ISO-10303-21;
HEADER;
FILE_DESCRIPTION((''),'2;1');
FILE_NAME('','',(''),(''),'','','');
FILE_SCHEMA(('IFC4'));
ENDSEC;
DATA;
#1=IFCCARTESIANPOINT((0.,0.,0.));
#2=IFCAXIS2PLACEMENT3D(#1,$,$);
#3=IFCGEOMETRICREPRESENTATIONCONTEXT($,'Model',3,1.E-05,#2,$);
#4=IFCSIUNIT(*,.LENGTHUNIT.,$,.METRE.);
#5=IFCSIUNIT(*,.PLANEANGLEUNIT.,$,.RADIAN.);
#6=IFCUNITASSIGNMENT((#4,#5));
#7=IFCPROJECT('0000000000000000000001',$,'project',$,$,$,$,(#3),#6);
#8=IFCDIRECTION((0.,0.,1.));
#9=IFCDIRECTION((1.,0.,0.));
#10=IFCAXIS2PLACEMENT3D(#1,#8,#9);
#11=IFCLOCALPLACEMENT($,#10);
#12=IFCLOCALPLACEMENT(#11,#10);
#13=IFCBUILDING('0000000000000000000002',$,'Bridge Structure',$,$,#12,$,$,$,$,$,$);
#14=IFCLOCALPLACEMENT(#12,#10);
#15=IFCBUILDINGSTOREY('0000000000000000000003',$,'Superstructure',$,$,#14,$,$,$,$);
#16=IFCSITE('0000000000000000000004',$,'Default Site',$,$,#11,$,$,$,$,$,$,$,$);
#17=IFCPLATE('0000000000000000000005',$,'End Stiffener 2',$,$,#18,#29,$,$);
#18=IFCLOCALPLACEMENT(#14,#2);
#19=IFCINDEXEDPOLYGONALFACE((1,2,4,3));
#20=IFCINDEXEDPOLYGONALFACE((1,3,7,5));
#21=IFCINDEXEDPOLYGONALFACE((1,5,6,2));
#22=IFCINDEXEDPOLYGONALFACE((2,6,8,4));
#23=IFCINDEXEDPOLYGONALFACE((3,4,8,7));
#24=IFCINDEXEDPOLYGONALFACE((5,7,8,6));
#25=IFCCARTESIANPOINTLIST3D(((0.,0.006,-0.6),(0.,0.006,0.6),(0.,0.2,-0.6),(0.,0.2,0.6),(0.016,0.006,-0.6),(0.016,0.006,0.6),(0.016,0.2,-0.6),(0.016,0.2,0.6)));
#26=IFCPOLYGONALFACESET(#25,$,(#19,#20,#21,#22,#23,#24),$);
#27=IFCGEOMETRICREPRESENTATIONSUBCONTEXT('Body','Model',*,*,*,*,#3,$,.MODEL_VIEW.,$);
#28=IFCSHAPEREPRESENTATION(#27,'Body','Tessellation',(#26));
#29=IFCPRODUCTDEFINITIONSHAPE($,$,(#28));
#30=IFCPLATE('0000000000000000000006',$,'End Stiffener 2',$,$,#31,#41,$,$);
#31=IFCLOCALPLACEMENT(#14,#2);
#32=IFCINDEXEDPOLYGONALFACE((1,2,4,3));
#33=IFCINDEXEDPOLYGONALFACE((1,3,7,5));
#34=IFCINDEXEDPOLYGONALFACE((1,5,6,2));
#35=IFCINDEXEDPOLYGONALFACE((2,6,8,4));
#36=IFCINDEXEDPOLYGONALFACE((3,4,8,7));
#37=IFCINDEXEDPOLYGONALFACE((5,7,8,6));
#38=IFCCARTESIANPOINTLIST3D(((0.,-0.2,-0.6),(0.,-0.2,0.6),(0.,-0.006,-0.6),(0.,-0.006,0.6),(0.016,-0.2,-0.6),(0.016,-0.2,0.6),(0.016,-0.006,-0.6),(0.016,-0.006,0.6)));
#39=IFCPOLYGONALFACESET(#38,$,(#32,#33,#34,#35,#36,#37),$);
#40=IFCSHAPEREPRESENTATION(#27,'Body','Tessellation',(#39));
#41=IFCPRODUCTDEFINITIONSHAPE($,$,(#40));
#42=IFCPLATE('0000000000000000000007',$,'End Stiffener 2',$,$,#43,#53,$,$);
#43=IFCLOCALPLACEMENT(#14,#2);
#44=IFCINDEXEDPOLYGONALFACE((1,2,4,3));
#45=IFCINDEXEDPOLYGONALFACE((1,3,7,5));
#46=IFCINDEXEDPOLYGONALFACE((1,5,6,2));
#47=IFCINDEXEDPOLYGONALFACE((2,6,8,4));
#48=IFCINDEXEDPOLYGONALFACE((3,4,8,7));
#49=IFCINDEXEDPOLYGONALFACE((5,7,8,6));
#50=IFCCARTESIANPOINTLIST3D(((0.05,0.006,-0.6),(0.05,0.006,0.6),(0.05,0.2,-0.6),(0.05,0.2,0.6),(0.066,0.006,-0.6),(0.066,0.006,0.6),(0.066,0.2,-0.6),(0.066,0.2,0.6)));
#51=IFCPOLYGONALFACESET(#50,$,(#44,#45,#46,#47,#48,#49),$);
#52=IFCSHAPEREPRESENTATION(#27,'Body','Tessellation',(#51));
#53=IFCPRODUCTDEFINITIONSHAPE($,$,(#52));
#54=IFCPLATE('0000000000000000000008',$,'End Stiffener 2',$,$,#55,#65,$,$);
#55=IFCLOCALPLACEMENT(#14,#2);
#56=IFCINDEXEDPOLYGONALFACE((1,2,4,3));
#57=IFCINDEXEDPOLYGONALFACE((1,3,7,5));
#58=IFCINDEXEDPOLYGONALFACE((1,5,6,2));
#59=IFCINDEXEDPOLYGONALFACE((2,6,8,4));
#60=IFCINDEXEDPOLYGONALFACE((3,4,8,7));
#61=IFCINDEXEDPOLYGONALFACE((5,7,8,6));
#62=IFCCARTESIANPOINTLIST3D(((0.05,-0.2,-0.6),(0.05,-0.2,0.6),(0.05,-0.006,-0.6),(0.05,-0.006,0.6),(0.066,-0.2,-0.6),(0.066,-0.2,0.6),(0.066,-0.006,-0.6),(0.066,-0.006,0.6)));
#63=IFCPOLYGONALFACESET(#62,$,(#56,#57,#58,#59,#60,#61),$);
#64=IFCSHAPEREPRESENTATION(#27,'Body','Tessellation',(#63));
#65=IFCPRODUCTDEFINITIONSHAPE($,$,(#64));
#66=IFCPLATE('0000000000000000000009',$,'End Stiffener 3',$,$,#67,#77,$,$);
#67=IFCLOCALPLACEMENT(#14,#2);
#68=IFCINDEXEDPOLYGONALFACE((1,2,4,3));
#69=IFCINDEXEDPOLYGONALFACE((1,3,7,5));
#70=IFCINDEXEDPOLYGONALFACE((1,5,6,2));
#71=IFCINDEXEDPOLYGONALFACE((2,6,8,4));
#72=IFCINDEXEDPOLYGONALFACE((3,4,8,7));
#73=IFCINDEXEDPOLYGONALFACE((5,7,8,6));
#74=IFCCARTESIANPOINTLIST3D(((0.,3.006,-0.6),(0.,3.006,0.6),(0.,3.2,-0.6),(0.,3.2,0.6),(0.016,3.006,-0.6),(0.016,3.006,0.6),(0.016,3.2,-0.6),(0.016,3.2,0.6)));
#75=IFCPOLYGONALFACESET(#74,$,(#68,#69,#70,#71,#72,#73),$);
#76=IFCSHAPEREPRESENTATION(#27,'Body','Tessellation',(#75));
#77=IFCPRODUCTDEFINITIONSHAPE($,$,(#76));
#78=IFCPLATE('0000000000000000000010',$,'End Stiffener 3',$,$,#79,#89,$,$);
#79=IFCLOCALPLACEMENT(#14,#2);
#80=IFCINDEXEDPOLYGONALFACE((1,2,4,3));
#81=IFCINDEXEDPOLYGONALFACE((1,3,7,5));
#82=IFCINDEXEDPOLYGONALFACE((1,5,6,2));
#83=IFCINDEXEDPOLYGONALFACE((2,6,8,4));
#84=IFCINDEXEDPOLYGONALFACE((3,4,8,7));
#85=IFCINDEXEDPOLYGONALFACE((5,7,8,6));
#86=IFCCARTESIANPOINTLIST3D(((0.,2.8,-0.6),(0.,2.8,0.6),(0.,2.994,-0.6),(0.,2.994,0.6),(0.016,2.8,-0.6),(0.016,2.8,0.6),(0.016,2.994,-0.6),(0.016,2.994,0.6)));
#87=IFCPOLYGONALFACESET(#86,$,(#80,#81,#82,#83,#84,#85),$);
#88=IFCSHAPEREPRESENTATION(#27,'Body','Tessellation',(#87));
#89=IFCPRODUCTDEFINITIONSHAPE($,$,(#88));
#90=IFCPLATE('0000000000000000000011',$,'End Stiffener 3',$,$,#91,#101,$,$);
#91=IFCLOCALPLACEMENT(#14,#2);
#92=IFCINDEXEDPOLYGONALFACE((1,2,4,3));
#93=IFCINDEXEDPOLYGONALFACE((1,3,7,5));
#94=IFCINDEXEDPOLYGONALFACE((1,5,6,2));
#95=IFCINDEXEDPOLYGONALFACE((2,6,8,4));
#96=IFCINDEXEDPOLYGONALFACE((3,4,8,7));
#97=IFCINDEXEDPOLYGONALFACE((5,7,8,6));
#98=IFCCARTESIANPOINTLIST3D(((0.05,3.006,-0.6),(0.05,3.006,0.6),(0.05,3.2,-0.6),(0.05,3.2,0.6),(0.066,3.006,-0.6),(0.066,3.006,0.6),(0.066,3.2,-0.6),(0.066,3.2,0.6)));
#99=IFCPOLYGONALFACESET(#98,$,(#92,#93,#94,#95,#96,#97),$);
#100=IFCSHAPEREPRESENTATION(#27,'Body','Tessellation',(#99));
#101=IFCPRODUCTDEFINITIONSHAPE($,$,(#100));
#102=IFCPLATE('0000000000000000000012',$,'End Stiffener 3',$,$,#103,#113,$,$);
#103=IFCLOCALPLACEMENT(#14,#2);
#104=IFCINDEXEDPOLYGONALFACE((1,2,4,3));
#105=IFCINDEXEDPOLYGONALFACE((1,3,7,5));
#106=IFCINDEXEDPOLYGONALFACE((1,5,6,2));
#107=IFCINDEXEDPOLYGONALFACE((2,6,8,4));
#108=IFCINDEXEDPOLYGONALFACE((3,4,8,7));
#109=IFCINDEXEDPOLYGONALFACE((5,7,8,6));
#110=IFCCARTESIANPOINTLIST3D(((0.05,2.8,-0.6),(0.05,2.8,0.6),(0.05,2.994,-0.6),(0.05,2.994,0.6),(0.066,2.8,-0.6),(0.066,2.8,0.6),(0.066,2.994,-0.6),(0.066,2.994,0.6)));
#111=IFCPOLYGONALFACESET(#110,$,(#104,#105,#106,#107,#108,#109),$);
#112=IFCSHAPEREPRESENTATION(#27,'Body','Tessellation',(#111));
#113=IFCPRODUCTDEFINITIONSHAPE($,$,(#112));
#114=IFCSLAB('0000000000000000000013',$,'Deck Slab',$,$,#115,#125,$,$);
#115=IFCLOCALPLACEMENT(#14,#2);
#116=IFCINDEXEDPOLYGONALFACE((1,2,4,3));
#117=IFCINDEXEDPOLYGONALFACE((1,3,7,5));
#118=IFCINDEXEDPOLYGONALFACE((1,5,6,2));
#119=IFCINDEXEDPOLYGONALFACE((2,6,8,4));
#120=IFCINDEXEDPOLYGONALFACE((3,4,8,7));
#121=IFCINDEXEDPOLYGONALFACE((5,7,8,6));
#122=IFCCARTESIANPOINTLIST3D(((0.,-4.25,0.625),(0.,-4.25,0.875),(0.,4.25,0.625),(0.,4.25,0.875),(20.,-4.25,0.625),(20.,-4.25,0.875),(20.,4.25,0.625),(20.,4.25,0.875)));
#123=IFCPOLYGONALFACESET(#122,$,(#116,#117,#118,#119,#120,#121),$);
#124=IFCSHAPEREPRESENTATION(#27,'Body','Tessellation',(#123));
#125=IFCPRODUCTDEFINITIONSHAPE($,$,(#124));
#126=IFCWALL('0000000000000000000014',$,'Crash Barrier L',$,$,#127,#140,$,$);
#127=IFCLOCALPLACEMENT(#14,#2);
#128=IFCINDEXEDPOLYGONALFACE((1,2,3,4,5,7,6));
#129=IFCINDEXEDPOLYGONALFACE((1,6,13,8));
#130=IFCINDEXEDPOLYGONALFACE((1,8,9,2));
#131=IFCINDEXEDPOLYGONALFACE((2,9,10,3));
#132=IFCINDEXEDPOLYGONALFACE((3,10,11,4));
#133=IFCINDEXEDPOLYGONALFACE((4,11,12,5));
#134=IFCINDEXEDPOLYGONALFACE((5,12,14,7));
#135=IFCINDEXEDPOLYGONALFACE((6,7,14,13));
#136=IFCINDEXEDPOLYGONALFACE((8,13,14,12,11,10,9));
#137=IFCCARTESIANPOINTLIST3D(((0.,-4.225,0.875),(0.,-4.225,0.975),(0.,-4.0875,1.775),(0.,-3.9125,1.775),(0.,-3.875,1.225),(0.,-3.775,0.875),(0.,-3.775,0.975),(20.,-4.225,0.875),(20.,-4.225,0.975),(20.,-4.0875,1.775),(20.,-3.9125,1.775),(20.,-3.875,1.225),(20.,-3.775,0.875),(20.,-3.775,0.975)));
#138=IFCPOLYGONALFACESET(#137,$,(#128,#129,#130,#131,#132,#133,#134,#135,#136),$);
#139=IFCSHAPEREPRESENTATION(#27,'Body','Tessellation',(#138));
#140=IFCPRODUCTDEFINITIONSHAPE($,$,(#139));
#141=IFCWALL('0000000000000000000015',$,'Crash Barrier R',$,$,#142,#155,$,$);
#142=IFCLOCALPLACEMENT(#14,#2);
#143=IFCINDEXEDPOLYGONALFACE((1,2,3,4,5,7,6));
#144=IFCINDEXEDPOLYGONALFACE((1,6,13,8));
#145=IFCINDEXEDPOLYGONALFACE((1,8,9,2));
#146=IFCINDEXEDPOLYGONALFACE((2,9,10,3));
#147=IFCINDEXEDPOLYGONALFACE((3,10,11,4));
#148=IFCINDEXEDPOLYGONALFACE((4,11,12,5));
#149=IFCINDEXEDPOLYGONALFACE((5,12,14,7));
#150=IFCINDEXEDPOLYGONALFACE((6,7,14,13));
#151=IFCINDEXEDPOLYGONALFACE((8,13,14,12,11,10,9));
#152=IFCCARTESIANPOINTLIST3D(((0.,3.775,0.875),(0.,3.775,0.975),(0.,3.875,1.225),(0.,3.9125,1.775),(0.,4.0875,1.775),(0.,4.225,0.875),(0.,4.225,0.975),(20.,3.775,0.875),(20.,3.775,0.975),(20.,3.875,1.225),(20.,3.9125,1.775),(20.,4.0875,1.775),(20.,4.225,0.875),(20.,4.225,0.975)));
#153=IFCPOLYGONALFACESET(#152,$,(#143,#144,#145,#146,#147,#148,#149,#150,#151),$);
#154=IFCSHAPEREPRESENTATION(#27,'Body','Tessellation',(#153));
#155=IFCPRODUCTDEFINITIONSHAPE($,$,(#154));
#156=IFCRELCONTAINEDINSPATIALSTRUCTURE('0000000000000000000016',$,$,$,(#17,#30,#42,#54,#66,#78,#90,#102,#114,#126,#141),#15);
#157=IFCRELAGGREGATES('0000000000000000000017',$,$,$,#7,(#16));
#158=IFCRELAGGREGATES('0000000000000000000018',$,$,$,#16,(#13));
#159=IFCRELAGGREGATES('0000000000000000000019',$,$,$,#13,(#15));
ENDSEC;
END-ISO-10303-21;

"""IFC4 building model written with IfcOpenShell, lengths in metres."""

from ifc_helpers import new_model, si_unit, frame, origin, origin_with_axes, origin_2d_with_axis, place, context, subcontext, project, spatial, polyline, rectangle, outline, extrude, element, save


model = new_model("IFC4")

# Units and contexts
model_context = context("Model", 3, precision=1e-05, world=origin())
body_context = subcontext(model_context, "Body", "Model", "MODEL_VIEW")
ifc_project = project(units=[si_unit("LENGTHUNIT", "METRE"), si_unit("PLANEANGLEUNIT", "RADIAN")], contexts=[model_context])

# Site, building, storey
site_placement = place(None, origin_with_axes())
site = spatial("IfcSite", under=ifc_project, at=site_placement, Name="Default Site")
building_placement = place(site_placement, origin_with_axes())
building = spatial("IfcBuilding", under=site, at=building_placement, Name="Bridge Structure")
storey_placement = place(building_placement, origin_with_axes())
storey = spatial("IfcBuildingStorey", under=building, at=storey_placement, Name="Superstructure")

# Plates
for number, where, z_axis, x_axis, name in (
    (1, (0.008, 0.103, -0.6), (0.0, 0.0, 1.0), (1.0, 0.0, 0.0), "End Stiffener 2"),
    (2, (0.008, -0.103, -0.6), (0.0, 0.0, 1.0), (1.0, 0.0, 0.0), "End Stiffener 2"),
    (3, (0.058, 0.103, -0.6), (0.0, 0.0, 1.0), (1.0, 0.0, 0.0), "End Stiffener 2"),
    (4, (0.058, -0.103, -0.6), (0.0, 0.0, 1.0), (1.0, 0.0, 0.0), "End Stiffener 2"),
    (5, (0.008, 3.103, -0.6), (0.0, 0.0, 1.0), (1.0, 0.0, 0.0), "End Stiffener 3"),
    (6, (0.008, 2.897, -0.6), (0.0, 0.0, 1.0), (1.0, 0.0, 0.0), "End Stiffener 3"),
    (7, (0.058, 3.103, -0.6), (0.0, 0.0, 1.0), (1.0, 0.0, 0.0), "End Stiffener 3"),
    (8, (0.058, 2.897, -0.6), (0.0, 0.0, 1.0), (1.0, 0.0, 0.0), "End Stiffener 3"),
):
    element("IfcPlate", number, at=place(storey_placement, frame(where, z_axis=z_axis, x_axis=x_axis)), inside=storey, Name=name, context=body_context, shape_type="SweptSolid", body=[
        extrude(rectangle(XDim=0.016, YDim=0.194, at=origin_2d_with_axis()), origin_with_axes(), (0.0, 0.0, 1.0), 1.2),
    ])

# Slab
slab_placement = place(storey_placement, frame((0.0, 0.0, 0.625), z_axis=(0.0, 0.0, 1.0), x_axis=(1.0, 0.0, 0.0)))
element("IfcSlab", 9, at=slab_placement, inside=storey, Name="Deck Slab", context=body_context, shape_type="SweptSolid", body=[
    extrude(outline(polyline([(0.0, -4.25), (20.0, -4.25), (20.0, 4.25), (0.0, 4.25), (0.0, -4.25)])), origin_with_axes(), (0.0, 0.0, 1.0), 0.25),
])

# Walls
wall_1_placement = place(storey_placement, frame((0.0, -4.225, 0.875), z_axis=(1.0, 0.0, 0.0), x_axis=(0.0, 1.0, 0.0)))
element("IfcWall", 10, at=wall_1_placement, inside=storey, Name="Crash Barrier L", context=body_context, shape_type="SweptSolid", body=[
    extrude(outline(polyline([(0.0, 0.0), (0.45, 0.0), (0.45, 0.1), (0.35, 0.35), (0.3125, 0.9), (0.1375, 0.9), (0.0, 0.1), (0.0, 0.0)])), origin_with_axes(), (0.0, 0.0, 1.0), 20.0),
])
wall_2_placement = place(storey_placement, frame((0.0, 3.775, 0.875), z_axis=(1.0, 0.0, 0.0), x_axis=(0.0, 1.0, 0.0)))
element("IfcWall", 11, at=wall_2_placement, inside=storey, Name="Crash Barrier R", context=body_context, shape_type="SweptSolid", body=[
    extrude(outline(polyline([(0.45, 0.0), (0.0, 0.0), (0.0, 0.1), (0.1, 0.35), (0.1375, 0.9), (0.3125, 0.9), (0.45, 0.1), (0.45, 0.0)])), origin_with_axes(), (0.0, 0.0, 1.0), 20.0),
])

save(model, "model.ifc")
